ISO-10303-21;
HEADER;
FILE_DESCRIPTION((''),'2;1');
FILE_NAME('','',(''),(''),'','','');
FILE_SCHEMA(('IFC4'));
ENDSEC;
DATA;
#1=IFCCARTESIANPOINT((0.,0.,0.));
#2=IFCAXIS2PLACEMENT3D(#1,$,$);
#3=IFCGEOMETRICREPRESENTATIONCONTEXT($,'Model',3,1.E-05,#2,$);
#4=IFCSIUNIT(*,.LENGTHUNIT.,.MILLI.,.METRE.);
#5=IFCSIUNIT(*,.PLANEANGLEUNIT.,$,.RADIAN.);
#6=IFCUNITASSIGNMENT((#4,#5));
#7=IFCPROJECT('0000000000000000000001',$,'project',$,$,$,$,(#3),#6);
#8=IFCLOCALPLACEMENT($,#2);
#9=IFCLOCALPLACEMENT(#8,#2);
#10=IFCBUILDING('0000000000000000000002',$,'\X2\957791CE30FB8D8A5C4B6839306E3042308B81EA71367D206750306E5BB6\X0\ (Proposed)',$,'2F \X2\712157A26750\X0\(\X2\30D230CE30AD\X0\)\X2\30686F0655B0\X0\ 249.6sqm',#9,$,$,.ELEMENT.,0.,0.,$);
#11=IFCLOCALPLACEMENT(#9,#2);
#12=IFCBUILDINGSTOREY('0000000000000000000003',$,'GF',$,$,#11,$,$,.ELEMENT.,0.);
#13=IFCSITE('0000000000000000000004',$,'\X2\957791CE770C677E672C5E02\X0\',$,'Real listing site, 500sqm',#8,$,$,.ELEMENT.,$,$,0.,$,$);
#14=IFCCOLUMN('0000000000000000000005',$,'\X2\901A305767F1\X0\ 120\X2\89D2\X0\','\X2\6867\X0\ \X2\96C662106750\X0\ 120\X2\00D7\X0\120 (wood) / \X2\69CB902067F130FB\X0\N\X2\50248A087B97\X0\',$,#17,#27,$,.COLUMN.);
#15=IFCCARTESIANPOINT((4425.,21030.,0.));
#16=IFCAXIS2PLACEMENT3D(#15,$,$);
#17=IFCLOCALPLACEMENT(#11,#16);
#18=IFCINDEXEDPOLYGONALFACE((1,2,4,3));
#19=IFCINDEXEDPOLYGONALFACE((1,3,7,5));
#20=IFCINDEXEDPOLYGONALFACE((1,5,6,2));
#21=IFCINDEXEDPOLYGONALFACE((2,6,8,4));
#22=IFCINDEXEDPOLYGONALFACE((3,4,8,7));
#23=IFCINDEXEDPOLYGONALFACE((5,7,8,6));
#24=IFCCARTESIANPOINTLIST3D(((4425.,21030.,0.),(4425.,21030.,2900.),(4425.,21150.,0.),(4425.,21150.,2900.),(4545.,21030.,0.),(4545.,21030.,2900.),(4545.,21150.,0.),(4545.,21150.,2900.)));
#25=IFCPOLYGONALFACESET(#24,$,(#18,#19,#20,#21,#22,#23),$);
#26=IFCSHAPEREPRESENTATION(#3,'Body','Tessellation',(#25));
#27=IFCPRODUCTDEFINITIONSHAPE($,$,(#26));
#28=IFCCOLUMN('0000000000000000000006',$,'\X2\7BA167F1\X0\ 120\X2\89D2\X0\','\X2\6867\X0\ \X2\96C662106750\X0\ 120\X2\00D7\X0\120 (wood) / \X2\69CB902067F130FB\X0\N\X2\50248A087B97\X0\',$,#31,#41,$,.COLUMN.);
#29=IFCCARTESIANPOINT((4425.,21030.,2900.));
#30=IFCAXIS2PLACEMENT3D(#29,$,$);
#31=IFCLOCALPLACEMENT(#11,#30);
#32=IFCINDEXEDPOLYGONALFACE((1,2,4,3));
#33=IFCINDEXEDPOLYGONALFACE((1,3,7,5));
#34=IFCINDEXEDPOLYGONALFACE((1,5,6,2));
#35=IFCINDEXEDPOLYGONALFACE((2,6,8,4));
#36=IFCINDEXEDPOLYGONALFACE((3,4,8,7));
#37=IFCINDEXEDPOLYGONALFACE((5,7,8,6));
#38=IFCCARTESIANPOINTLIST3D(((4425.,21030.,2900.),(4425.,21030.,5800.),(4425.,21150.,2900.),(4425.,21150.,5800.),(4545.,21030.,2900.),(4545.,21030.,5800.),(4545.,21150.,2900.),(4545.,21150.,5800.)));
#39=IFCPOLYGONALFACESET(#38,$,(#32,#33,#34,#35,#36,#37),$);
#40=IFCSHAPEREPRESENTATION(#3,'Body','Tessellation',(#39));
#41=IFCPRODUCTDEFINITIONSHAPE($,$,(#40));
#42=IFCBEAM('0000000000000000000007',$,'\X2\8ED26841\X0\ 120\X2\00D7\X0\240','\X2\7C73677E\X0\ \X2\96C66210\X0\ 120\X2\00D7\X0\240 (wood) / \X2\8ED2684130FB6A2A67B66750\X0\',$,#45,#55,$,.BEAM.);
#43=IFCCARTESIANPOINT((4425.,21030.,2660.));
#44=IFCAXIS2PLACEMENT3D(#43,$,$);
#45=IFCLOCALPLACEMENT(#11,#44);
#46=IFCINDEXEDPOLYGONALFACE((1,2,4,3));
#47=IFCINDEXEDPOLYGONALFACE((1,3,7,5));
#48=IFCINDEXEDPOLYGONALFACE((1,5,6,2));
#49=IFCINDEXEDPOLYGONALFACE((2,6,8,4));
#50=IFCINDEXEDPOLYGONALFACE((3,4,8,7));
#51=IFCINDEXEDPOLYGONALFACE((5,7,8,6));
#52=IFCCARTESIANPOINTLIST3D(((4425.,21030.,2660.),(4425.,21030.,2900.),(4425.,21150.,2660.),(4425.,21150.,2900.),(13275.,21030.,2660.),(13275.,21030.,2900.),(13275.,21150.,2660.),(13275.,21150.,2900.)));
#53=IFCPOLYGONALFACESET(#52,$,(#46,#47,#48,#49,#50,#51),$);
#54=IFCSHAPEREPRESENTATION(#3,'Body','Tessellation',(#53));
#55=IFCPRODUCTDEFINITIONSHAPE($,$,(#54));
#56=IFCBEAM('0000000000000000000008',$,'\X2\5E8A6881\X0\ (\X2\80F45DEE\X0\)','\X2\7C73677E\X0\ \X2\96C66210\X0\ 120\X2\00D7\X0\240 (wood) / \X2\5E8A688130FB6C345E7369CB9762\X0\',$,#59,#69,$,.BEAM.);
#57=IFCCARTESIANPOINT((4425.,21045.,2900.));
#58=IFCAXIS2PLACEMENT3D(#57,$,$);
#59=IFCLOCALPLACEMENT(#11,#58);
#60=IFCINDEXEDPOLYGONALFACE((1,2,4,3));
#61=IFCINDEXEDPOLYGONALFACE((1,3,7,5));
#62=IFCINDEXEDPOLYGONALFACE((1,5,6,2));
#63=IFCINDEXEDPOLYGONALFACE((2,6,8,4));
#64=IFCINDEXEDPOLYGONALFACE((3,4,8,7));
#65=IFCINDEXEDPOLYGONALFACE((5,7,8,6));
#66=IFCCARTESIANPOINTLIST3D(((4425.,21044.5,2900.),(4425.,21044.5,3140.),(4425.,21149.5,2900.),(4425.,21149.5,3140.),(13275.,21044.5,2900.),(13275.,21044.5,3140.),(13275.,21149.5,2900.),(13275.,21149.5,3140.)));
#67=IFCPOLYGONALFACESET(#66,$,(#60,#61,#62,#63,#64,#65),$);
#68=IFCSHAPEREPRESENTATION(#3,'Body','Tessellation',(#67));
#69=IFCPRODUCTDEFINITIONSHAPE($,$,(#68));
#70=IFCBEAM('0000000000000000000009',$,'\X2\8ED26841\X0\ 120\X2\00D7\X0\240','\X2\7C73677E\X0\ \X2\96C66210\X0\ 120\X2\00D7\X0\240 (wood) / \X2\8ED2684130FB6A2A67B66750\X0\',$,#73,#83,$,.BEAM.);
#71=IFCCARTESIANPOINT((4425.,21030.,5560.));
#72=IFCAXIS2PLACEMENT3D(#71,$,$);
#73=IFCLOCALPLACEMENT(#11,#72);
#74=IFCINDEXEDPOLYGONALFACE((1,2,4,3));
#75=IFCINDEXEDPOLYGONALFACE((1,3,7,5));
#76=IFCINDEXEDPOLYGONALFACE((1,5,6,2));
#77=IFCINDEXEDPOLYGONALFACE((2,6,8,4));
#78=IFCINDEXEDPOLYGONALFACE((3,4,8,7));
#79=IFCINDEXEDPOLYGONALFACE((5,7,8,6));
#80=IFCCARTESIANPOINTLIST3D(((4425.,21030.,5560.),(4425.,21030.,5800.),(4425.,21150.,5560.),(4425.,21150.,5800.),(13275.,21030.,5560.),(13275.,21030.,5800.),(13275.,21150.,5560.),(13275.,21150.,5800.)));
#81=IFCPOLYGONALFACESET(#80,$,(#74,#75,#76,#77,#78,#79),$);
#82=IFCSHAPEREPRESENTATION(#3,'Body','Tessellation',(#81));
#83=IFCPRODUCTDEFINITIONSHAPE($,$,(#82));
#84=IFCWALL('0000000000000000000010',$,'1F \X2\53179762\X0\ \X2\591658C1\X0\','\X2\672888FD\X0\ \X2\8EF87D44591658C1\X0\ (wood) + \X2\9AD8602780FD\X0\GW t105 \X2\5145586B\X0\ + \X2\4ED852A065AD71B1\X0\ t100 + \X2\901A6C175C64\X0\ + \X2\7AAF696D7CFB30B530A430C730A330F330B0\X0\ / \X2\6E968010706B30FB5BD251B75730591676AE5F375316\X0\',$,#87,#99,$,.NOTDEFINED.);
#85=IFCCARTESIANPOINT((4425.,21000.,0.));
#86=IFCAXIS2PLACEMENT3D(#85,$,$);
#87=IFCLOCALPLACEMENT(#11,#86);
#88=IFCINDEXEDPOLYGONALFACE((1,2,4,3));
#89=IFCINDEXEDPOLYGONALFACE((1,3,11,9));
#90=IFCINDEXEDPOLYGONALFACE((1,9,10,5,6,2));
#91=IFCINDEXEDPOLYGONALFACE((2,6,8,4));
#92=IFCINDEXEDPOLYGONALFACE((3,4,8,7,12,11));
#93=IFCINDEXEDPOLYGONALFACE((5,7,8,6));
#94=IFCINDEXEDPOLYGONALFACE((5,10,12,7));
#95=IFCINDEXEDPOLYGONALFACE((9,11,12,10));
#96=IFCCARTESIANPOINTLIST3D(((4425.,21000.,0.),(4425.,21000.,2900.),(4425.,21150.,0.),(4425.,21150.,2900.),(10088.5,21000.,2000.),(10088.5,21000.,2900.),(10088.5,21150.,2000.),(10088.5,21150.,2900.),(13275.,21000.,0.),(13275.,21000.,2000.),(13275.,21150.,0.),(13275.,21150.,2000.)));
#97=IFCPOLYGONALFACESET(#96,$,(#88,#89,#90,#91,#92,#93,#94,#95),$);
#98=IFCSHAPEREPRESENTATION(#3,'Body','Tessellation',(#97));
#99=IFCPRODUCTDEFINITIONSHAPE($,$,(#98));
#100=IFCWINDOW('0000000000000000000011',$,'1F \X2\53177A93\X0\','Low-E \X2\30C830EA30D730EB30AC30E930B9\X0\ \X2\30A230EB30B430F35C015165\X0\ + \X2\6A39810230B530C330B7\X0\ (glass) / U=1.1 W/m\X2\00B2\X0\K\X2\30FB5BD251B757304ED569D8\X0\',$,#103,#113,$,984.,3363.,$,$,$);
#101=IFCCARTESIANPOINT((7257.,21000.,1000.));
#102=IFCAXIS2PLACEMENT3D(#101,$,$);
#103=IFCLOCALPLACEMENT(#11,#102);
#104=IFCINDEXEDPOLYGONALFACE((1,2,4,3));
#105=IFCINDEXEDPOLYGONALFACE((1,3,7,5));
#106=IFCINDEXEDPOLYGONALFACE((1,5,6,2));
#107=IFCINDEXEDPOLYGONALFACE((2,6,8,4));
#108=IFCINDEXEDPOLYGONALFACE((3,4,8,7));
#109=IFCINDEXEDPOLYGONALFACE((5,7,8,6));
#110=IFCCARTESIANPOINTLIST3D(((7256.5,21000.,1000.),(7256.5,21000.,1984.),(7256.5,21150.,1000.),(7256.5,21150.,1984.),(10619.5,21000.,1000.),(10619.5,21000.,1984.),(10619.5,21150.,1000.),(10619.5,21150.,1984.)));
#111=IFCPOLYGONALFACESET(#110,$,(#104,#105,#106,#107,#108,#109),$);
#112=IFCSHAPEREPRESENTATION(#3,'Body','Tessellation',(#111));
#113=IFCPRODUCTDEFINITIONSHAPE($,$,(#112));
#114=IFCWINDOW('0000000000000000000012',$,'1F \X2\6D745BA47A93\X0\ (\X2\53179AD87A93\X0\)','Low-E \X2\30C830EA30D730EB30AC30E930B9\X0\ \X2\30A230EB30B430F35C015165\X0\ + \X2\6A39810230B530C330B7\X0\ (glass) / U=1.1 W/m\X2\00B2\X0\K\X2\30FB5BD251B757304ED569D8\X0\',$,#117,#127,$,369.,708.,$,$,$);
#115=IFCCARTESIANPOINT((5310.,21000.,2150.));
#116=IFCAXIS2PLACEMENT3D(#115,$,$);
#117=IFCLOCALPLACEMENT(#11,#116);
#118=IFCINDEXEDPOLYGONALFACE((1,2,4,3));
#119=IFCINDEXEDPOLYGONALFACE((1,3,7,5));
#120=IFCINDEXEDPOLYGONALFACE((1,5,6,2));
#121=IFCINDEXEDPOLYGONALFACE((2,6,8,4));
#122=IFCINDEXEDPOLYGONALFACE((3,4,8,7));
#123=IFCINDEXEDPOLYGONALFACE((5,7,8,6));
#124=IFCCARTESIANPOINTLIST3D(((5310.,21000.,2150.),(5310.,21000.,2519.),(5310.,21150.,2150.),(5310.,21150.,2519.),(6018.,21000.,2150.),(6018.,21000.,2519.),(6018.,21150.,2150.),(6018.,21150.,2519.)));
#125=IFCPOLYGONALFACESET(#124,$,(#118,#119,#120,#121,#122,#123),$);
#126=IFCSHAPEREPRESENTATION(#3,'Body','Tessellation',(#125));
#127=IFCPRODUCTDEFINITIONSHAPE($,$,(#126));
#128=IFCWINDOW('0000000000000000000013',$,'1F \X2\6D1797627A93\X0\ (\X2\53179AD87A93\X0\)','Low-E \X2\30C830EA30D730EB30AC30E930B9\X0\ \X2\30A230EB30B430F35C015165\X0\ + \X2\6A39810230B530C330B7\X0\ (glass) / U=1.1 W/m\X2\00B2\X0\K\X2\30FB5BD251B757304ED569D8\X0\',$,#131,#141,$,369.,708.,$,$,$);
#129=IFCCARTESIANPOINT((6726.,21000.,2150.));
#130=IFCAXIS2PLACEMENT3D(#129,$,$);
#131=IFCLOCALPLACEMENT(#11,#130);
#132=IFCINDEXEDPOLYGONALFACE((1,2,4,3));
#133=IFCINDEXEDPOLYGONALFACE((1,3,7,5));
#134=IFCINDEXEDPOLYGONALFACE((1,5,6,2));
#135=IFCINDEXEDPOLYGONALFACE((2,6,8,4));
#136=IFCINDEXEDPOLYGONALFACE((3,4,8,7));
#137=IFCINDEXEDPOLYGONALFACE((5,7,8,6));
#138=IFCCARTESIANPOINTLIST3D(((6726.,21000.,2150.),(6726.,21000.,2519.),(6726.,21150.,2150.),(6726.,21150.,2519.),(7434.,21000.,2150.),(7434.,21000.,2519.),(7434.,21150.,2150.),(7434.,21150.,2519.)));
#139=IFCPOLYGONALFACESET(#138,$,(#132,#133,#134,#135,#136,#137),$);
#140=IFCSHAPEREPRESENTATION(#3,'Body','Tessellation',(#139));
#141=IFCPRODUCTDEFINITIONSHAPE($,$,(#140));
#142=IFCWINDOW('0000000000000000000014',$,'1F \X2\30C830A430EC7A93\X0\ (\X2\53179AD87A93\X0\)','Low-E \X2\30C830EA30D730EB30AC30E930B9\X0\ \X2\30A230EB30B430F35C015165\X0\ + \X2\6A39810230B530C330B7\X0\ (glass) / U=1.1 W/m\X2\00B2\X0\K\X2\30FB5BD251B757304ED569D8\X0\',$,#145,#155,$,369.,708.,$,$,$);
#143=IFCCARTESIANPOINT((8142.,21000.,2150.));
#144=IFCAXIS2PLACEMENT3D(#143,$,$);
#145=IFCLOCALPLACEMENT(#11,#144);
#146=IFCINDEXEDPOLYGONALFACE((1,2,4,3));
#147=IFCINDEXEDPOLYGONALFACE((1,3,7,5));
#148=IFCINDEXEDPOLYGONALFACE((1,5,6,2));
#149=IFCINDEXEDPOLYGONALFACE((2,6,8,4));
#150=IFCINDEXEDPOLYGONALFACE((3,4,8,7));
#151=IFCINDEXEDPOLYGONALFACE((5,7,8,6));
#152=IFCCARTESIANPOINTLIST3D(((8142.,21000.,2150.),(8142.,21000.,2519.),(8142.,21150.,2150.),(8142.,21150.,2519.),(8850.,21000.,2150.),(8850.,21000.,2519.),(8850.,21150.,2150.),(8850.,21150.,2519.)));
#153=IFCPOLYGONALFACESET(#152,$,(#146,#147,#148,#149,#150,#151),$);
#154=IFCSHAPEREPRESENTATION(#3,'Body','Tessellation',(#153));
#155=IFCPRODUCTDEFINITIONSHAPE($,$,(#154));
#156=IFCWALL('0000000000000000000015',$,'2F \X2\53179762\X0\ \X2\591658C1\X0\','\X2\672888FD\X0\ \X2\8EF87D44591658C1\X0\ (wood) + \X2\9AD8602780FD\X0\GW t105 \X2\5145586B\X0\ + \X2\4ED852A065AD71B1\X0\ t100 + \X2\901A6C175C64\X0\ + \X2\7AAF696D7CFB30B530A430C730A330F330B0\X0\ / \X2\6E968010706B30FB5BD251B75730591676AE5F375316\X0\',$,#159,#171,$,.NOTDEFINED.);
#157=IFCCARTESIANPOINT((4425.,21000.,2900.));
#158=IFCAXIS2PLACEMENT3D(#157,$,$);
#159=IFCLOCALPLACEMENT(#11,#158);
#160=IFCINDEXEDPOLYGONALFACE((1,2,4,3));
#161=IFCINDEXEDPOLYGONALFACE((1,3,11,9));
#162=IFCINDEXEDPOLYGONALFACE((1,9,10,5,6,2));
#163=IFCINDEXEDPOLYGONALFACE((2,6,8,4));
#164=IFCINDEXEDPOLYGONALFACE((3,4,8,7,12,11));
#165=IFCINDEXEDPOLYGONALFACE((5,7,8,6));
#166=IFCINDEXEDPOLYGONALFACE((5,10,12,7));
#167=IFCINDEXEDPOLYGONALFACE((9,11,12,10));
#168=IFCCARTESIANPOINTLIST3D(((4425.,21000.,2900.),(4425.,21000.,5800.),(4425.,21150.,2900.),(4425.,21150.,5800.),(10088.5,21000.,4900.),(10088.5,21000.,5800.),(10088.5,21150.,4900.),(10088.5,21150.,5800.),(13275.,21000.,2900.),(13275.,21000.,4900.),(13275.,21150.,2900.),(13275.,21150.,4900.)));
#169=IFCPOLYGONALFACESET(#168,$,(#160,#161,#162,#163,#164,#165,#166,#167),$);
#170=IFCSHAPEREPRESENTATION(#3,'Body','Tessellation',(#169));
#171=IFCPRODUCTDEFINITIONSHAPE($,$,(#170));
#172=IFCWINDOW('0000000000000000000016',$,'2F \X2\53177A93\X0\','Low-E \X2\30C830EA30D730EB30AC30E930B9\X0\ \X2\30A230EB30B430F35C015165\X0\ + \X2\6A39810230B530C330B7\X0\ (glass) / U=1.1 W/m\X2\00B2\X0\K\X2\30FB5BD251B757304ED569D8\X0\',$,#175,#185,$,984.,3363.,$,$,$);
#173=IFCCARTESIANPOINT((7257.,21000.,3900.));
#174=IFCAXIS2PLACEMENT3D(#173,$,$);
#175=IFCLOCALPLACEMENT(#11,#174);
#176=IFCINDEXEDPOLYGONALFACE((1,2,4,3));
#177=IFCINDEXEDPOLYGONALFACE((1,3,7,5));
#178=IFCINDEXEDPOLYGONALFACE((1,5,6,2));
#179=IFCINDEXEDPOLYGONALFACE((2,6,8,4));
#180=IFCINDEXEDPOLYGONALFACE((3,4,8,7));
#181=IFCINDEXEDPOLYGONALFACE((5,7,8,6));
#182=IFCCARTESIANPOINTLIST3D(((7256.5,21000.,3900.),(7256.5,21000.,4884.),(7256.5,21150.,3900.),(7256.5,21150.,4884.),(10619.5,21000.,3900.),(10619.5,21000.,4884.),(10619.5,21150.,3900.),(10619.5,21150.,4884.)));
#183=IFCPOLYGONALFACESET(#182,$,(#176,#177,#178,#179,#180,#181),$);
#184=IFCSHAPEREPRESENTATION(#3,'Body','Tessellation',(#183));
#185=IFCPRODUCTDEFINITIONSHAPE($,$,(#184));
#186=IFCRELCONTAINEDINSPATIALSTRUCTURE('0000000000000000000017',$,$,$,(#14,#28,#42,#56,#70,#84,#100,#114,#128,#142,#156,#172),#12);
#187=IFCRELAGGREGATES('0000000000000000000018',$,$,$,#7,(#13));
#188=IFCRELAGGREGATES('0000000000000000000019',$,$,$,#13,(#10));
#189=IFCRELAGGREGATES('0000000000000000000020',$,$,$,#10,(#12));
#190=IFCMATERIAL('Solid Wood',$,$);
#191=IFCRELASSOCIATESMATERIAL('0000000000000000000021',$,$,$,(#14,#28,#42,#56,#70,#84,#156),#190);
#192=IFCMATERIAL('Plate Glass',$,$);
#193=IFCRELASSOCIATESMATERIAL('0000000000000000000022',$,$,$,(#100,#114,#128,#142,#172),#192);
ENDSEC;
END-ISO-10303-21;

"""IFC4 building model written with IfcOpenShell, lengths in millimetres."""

from ifc_helpers import new_model, si_unit, frame, frame_2d, origin, place, context, project, spatial, rectangle, extrude, material, element, fill, save


model = new_model("IFC4")

# Units and contexts
model_context = context("Model", 3, precision=1e-05, world=origin())
ifc_project = project(units=[si_unit("LENGTHUNIT", "METRE", prefix="MILLI"), si_unit("PLANEANGLEUNIT", "RADIAN")], contexts=[model_context])

# Site, building, storey
site_placement = place(None, origin())
site = spatial("IfcSite", under=ifc_project, at=site_placement, Name="長野県松本市", ObjectType="Real listing site, 500sqm", CompositionType="ELEMENT", RefElevation=0.0)
building_placement = place(site_placement, origin())
building = spatial("IfcBuilding", under=site, at=building_placement, Name="長野・越屋根のある自然素材の家 (Proposed)", ObjectType="2F 無垢材(ヒノキ)と漆喰 249.6sqm", CompositionType="ELEMENT", ElevationOfRefHeight=0.0, ElevationOfTerrain=0.0)
storey_placement = place(building_placement, origin())
storey = spatial("IfcBuildingStorey", under=building, at=storey_placement, Name="GF", CompositionType="ELEMENT", Elevation=0.0)

# Columns
ifc_material_1 = material(Name="Solid Wood")
column_1_placement = place(storey_placement, frame((4425.0, 21030.0, 0.0)))
element("IfcColumn", 1, at=column_1_placement, inside=storey, material=ifc_material_1, Name="通し柱 120角", Description="桧 集成材 120×120 (wood) / 構造柱・N値計算", PredefinedType="COLUMN", context=model_context, shape_type="SweptSolid", body=[
    extrude(rectangle(XDim=120.0, YDim=120.0, at=frame_2d((60.0, 60.0))), frame((4425.0, 21030.0, 0.0)), (0.0, 0.0, 1.0), 2900.0),
])
column_2_placement = place(storey_placement, frame((4425.0, 21030.0, 2900.0)))
element("IfcColumn", 2, at=column_2_placement, inside=storey, material=ifc_material_1, Name="管柱 120角", Description="桧 集成材 120×120 (wood) / 構造柱・N値計算", PredefinedType="COLUMN", context=model_context, shape_type="SweptSolid", body=[
    extrude(rectangle(XDim=120.0, YDim=120.0, at=frame_2d((60.0, 60.0))), frame((4425.0, 21030.0, 2900.0)), (0.0, 0.0, 1.0), 2900.0),
])

# Beams
beam_1_placement = place(storey_placement, frame((4425.0, 21030.0, 2660.0)))
element("IfcBeam", 3, at=beam_1_placement, inside=storey, material=ifc_material_1, Name="軒桁 120×240", Description="米松 集成 120×240 (wood) / 軒桁・横架材", PredefinedType="BEAM", context=model_context, shape_type="SweptSolid", body=[
    extrude(rectangle(XDim=8850.0, YDim=120.0, at=frame_2d((4425.0, 60.0))), frame((4425.0, 21030.0, 2660.0)), (0.0, 0.0, 1.0), 240.0),
])
beam_2_placement = place(storey_placement, frame((4425.0, 21045.0, 2900.0)))
element("IfcBeam", 4, at=beam_2_placement, inside=storey, material=ifc_material_1, Name="床梁 (胴差)", Description="米松 集成 120×240 (wood) / 床梁・水平構面", PredefinedType="BEAM", context=model_context, shape_type="SweptSolid", body=[
    extrude(rectangle(XDim=8850.0, YDim=105.0, at=frame_2d((4425.0, 52.0))), frame((4425.0, 21045.0, 2900.0)), (0.0, 0.0, 1.0), 240.0),
])
beam_3_placement = place(storey_placement, frame((4425.0, 21030.0, 5560.0)))
element("IfcBeam", 5, at=beam_3_placement, inside=storey, material=ifc_material_1, Name="軒桁 120×240", Description="米松 集成 120×240 (wood) / 軒桁・横架材", PredefinedType="BEAM", context=model_context, shape_type="SweptSolid", body=[
    extrude(rectangle(XDim=8850.0, YDim=120.0, at=frame_2d((4425.0, 60.0))), frame((4425.0, 21030.0, 5560.0)), (0.0, 0.0, 1.0), 240.0),
])

# Wall, openings, windows
wall_1_placement = place(storey_placement, frame((4425.0, 21000.0, 0.0)))
wall_1 = element("IfcWall", 6, at=wall_1_placement, inside=storey, material=ifc_material_1, Name="1F 北面 外壁", Description="木製 軸組外壁 (wood) + 高性能GW t105 充填 + 付加断熱 t100 + 通気層 + 窯業系サイディング / 準耐火・寒冷地外皮強化", PredefinedType="NOTDEFINED", context=model_context, shape_type="SweptSolid", body=[
    extrude(rectangle(XDim=8850.0, YDim=150.0, at=frame_2d((4425.0, 75.0))), frame((4425.0, 21000.0, 0.0)), (0.0, 0.0, 1.0), 2900.0),
])
opening_1_placement = place(storey_placement, frame((7257.0, 21000.0, 1000.0)))
opening_1 = element("IfcOpeningElement", 7, at=opening_1_placement, cuts=wall_1, PredefinedType="NOTDEFINED", context=model_context, shape_type="SweptSolid", body=[
    extrude(rectangle(XDim=3363.0, YDim=150.0, at=frame_2d((1681.0, 75.0))), frame((7257.0, 21000.0, 1000.0)), (0.0, 0.0, 1.0), 984.0),
])
opening_2_placement = place(storey_placement, frame((5310.0, 21000.0, 2150.0)))
opening_2 = element("IfcOpeningElement", 8, at=opening_2_placement, cuts=wall_1, PredefinedType="NOTDEFINED", context=model_context, shape_type="SweptSolid", body=[
    extrude(rectangle(XDim=708.0, YDim=150.0, at=frame_2d((354.0, 75.0))), frame((5310.0, 21000.0, 2150.0)), (0.0, 0.0, 1.0), 369.0),
])
opening_3_placement = place(storey_placement, frame((6726.0, 21000.0, 2150.0)))
opening_3 = element("IfcOpeningElement", 9, at=opening_3_placement, cuts=wall_1, PredefinedType="NOTDEFINED", context=model_context, shape_type="SweptSolid", body=[
    extrude(rectangle(XDim=708.0, YDim=150.0, at=frame_2d((354.0, 75.0))), frame((6726.0, 21000.0, 2150.0)), (0.0, 0.0, 1.0), 369.0),
])
opening_4_placement = place(storey_placement, frame((8142.0, 21000.0, 2150.0)))
opening_4 = element("IfcOpeningElement", 10, at=opening_4_placement, cuts=wall_1, PredefinedType="NOTDEFINED", context=model_context, shape_type="SweptSolid", body=[
    extrude(rectangle(XDim=708.0, YDim=150.0, at=frame_2d((354.0, 75.0))), frame((8142.0, 21000.0, 2150.0)), (0.0, 0.0, 1.0), 369.0),
])
ifc_material_2 = material(Name="Plate Glass")
window_1_placement = place(storey_placement, frame((7257.0, 21000.0, 1000.0)))
window_1 = element("IfcWindow", 11, at=window_1_placement, inside=storey, material=ifc_material_2, Name="1F 北窓", Description="Low-E トリプルガラス アルゴン封入 + 樹脂サッシ (glass) / U=1.1 W/m²K・寒冷地仕様", OverallHeight=984.0, OverallWidth=3363.0, context=model_context, shape_type="SweptSolid", body=[
    extrude(rectangle(XDim=3363.0, YDim=150.0, at=frame_2d((1681.0, 75.0))), frame((7257.0, 21000.0, 1000.0)), (0.0, 0.0, 1.0), 984.0),
])
fill(opening_1, window_1)
window_2_placement = place(storey_placement, frame((5310.0, 21000.0, 2150.0)))
window_2 = element("IfcWindow", 12, at=window_2_placement, inside=storey, material=ifc_material_2, Name="1F 浴室窓 (北高窓)", Description="Low-E トリプルガラス アルゴン封入 + 樹脂サッシ (glass) / U=1.1 W/m²K・寒冷地仕様", OverallHeight=369.0, OverallWidth=708.0, context=model_context, shape_type="SweptSolid", body=[
    extrude(rectangle(XDim=708.0, YDim=150.0, at=frame_2d((354.0, 75.0))), frame((5310.0, 21000.0, 2150.0)), (0.0, 0.0, 1.0), 369.0),
])
fill(opening_2, window_2)
window_3_placement = place(storey_placement, frame((6726.0, 21000.0, 2150.0)))
window_3 = element("IfcWindow", 13, at=window_3_placement, inside=storey, material=ifc_material_2, Name="1F 洗面窓 (北高窓)", Description="Low-E トリプルガラス アルゴン封入 + 樹脂サッシ (glass) / U=1.1 W/m²K・寒冷地仕様", OverallHeight=369.0, OverallWidth=708.0, context=model_context, shape_type="SweptSolid", body=[
    extrude(rectangle(XDim=708.0, YDim=150.0, at=frame_2d((354.0, 75.0))), frame((6726.0, 21000.0, 2150.0)), (0.0, 0.0, 1.0), 369.0),
])
fill(opening_3, window_3)
window_4_placement = place(storey_placement, frame((8142.0, 21000.0, 2150.0)))
window_4 = element("IfcWindow", 14, at=window_4_placement, inside=storey, material=ifc_material_2, Name="1F トイレ窓 (北高窓)", Description="Low-E トリプルガラス アルゴン封入 + 樹脂サッシ (glass) / U=1.1 W/m²K・寒冷地仕様", OverallHeight=369.0, OverallWidth=708.0, context=model_context, shape_type="SweptSolid", body=[
    extrude(rectangle(XDim=708.0, YDim=150.0, at=frame_2d((354.0, 75.0))), frame((8142.0, 21000.0, 2150.0)), (0.0, 0.0, 1.0), 369.0),
])
fill(opening_4, window_4)

# Wall, opening, window
wall_2_placement = place(storey_placement, frame((4425.0, 21000.0, 2900.0)))
wall_2 = element("IfcWall", 15, at=wall_2_placement, inside=storey, material=ifc_material_1, Name="2F 北面 外壁", Description="木製 軸組外壁 (wood) + 高性能GW t105 充填 + 付加断熱 t100 + 通気層 + 窯業系サイディング / 準耐火・寒冷地外皮強化", PredefinedType="NOTDEFINED", context=model_context, shape_type="SweptSolid", body=[
    extrude(rectangle(XDim=8850.0, YDim=150.0, at=frame_2d((4425.0, 75.0))), frame((4425.0, 21000.0, 2900.0)), (0.0, 0.0, 1.0), 2900.0),
])
opening_5_placement = place(storey_placement, frame((7257.0, 21000.0, 3900.0)))
opening_5 = element("IfcOpeningElement", 16, at=opening_5_placement, cuts=wall_2, PredefinedType="NOTDEFINED", context=model_context, shape_type="SweptSolid", body=[
    extrude(rectangle(XDim=3363.0, YDim=150.0, at=frame_2d((1681.0, 75.0))), frame((7257.0, 21000.0, 3900.0)), (0.0, 0.0, 1.0), 984.0),
])
window_5_placement = place(storey_placement, frame((7257.0, 21000.0, 3900.0)))
window_5 = element("IfcWindow", 17, at=window_5_placement, inside=storey, material=ifc_material_2, Name="2F 北窓", Description="Low-E トリプルガラス アルゴン封入 + 樹脂サッシ (glass) / U=1.1 W/m²K・寒冷地仕様", OverallHeight=984.0, OverallWidth=3363.0, context=model_context, shape_type="SweptSolid", body=[
    extrude(rectangle(XDim=3363.0, YDim=150.0, at=frame_2d((1681.0, 75.0))), frame((7257.0, 21000.0, 3900.0)), (0.0, 0.0, 1.0), 984.0),
])
fill(opening_5, window_5)

save(model, "model.ifc")
